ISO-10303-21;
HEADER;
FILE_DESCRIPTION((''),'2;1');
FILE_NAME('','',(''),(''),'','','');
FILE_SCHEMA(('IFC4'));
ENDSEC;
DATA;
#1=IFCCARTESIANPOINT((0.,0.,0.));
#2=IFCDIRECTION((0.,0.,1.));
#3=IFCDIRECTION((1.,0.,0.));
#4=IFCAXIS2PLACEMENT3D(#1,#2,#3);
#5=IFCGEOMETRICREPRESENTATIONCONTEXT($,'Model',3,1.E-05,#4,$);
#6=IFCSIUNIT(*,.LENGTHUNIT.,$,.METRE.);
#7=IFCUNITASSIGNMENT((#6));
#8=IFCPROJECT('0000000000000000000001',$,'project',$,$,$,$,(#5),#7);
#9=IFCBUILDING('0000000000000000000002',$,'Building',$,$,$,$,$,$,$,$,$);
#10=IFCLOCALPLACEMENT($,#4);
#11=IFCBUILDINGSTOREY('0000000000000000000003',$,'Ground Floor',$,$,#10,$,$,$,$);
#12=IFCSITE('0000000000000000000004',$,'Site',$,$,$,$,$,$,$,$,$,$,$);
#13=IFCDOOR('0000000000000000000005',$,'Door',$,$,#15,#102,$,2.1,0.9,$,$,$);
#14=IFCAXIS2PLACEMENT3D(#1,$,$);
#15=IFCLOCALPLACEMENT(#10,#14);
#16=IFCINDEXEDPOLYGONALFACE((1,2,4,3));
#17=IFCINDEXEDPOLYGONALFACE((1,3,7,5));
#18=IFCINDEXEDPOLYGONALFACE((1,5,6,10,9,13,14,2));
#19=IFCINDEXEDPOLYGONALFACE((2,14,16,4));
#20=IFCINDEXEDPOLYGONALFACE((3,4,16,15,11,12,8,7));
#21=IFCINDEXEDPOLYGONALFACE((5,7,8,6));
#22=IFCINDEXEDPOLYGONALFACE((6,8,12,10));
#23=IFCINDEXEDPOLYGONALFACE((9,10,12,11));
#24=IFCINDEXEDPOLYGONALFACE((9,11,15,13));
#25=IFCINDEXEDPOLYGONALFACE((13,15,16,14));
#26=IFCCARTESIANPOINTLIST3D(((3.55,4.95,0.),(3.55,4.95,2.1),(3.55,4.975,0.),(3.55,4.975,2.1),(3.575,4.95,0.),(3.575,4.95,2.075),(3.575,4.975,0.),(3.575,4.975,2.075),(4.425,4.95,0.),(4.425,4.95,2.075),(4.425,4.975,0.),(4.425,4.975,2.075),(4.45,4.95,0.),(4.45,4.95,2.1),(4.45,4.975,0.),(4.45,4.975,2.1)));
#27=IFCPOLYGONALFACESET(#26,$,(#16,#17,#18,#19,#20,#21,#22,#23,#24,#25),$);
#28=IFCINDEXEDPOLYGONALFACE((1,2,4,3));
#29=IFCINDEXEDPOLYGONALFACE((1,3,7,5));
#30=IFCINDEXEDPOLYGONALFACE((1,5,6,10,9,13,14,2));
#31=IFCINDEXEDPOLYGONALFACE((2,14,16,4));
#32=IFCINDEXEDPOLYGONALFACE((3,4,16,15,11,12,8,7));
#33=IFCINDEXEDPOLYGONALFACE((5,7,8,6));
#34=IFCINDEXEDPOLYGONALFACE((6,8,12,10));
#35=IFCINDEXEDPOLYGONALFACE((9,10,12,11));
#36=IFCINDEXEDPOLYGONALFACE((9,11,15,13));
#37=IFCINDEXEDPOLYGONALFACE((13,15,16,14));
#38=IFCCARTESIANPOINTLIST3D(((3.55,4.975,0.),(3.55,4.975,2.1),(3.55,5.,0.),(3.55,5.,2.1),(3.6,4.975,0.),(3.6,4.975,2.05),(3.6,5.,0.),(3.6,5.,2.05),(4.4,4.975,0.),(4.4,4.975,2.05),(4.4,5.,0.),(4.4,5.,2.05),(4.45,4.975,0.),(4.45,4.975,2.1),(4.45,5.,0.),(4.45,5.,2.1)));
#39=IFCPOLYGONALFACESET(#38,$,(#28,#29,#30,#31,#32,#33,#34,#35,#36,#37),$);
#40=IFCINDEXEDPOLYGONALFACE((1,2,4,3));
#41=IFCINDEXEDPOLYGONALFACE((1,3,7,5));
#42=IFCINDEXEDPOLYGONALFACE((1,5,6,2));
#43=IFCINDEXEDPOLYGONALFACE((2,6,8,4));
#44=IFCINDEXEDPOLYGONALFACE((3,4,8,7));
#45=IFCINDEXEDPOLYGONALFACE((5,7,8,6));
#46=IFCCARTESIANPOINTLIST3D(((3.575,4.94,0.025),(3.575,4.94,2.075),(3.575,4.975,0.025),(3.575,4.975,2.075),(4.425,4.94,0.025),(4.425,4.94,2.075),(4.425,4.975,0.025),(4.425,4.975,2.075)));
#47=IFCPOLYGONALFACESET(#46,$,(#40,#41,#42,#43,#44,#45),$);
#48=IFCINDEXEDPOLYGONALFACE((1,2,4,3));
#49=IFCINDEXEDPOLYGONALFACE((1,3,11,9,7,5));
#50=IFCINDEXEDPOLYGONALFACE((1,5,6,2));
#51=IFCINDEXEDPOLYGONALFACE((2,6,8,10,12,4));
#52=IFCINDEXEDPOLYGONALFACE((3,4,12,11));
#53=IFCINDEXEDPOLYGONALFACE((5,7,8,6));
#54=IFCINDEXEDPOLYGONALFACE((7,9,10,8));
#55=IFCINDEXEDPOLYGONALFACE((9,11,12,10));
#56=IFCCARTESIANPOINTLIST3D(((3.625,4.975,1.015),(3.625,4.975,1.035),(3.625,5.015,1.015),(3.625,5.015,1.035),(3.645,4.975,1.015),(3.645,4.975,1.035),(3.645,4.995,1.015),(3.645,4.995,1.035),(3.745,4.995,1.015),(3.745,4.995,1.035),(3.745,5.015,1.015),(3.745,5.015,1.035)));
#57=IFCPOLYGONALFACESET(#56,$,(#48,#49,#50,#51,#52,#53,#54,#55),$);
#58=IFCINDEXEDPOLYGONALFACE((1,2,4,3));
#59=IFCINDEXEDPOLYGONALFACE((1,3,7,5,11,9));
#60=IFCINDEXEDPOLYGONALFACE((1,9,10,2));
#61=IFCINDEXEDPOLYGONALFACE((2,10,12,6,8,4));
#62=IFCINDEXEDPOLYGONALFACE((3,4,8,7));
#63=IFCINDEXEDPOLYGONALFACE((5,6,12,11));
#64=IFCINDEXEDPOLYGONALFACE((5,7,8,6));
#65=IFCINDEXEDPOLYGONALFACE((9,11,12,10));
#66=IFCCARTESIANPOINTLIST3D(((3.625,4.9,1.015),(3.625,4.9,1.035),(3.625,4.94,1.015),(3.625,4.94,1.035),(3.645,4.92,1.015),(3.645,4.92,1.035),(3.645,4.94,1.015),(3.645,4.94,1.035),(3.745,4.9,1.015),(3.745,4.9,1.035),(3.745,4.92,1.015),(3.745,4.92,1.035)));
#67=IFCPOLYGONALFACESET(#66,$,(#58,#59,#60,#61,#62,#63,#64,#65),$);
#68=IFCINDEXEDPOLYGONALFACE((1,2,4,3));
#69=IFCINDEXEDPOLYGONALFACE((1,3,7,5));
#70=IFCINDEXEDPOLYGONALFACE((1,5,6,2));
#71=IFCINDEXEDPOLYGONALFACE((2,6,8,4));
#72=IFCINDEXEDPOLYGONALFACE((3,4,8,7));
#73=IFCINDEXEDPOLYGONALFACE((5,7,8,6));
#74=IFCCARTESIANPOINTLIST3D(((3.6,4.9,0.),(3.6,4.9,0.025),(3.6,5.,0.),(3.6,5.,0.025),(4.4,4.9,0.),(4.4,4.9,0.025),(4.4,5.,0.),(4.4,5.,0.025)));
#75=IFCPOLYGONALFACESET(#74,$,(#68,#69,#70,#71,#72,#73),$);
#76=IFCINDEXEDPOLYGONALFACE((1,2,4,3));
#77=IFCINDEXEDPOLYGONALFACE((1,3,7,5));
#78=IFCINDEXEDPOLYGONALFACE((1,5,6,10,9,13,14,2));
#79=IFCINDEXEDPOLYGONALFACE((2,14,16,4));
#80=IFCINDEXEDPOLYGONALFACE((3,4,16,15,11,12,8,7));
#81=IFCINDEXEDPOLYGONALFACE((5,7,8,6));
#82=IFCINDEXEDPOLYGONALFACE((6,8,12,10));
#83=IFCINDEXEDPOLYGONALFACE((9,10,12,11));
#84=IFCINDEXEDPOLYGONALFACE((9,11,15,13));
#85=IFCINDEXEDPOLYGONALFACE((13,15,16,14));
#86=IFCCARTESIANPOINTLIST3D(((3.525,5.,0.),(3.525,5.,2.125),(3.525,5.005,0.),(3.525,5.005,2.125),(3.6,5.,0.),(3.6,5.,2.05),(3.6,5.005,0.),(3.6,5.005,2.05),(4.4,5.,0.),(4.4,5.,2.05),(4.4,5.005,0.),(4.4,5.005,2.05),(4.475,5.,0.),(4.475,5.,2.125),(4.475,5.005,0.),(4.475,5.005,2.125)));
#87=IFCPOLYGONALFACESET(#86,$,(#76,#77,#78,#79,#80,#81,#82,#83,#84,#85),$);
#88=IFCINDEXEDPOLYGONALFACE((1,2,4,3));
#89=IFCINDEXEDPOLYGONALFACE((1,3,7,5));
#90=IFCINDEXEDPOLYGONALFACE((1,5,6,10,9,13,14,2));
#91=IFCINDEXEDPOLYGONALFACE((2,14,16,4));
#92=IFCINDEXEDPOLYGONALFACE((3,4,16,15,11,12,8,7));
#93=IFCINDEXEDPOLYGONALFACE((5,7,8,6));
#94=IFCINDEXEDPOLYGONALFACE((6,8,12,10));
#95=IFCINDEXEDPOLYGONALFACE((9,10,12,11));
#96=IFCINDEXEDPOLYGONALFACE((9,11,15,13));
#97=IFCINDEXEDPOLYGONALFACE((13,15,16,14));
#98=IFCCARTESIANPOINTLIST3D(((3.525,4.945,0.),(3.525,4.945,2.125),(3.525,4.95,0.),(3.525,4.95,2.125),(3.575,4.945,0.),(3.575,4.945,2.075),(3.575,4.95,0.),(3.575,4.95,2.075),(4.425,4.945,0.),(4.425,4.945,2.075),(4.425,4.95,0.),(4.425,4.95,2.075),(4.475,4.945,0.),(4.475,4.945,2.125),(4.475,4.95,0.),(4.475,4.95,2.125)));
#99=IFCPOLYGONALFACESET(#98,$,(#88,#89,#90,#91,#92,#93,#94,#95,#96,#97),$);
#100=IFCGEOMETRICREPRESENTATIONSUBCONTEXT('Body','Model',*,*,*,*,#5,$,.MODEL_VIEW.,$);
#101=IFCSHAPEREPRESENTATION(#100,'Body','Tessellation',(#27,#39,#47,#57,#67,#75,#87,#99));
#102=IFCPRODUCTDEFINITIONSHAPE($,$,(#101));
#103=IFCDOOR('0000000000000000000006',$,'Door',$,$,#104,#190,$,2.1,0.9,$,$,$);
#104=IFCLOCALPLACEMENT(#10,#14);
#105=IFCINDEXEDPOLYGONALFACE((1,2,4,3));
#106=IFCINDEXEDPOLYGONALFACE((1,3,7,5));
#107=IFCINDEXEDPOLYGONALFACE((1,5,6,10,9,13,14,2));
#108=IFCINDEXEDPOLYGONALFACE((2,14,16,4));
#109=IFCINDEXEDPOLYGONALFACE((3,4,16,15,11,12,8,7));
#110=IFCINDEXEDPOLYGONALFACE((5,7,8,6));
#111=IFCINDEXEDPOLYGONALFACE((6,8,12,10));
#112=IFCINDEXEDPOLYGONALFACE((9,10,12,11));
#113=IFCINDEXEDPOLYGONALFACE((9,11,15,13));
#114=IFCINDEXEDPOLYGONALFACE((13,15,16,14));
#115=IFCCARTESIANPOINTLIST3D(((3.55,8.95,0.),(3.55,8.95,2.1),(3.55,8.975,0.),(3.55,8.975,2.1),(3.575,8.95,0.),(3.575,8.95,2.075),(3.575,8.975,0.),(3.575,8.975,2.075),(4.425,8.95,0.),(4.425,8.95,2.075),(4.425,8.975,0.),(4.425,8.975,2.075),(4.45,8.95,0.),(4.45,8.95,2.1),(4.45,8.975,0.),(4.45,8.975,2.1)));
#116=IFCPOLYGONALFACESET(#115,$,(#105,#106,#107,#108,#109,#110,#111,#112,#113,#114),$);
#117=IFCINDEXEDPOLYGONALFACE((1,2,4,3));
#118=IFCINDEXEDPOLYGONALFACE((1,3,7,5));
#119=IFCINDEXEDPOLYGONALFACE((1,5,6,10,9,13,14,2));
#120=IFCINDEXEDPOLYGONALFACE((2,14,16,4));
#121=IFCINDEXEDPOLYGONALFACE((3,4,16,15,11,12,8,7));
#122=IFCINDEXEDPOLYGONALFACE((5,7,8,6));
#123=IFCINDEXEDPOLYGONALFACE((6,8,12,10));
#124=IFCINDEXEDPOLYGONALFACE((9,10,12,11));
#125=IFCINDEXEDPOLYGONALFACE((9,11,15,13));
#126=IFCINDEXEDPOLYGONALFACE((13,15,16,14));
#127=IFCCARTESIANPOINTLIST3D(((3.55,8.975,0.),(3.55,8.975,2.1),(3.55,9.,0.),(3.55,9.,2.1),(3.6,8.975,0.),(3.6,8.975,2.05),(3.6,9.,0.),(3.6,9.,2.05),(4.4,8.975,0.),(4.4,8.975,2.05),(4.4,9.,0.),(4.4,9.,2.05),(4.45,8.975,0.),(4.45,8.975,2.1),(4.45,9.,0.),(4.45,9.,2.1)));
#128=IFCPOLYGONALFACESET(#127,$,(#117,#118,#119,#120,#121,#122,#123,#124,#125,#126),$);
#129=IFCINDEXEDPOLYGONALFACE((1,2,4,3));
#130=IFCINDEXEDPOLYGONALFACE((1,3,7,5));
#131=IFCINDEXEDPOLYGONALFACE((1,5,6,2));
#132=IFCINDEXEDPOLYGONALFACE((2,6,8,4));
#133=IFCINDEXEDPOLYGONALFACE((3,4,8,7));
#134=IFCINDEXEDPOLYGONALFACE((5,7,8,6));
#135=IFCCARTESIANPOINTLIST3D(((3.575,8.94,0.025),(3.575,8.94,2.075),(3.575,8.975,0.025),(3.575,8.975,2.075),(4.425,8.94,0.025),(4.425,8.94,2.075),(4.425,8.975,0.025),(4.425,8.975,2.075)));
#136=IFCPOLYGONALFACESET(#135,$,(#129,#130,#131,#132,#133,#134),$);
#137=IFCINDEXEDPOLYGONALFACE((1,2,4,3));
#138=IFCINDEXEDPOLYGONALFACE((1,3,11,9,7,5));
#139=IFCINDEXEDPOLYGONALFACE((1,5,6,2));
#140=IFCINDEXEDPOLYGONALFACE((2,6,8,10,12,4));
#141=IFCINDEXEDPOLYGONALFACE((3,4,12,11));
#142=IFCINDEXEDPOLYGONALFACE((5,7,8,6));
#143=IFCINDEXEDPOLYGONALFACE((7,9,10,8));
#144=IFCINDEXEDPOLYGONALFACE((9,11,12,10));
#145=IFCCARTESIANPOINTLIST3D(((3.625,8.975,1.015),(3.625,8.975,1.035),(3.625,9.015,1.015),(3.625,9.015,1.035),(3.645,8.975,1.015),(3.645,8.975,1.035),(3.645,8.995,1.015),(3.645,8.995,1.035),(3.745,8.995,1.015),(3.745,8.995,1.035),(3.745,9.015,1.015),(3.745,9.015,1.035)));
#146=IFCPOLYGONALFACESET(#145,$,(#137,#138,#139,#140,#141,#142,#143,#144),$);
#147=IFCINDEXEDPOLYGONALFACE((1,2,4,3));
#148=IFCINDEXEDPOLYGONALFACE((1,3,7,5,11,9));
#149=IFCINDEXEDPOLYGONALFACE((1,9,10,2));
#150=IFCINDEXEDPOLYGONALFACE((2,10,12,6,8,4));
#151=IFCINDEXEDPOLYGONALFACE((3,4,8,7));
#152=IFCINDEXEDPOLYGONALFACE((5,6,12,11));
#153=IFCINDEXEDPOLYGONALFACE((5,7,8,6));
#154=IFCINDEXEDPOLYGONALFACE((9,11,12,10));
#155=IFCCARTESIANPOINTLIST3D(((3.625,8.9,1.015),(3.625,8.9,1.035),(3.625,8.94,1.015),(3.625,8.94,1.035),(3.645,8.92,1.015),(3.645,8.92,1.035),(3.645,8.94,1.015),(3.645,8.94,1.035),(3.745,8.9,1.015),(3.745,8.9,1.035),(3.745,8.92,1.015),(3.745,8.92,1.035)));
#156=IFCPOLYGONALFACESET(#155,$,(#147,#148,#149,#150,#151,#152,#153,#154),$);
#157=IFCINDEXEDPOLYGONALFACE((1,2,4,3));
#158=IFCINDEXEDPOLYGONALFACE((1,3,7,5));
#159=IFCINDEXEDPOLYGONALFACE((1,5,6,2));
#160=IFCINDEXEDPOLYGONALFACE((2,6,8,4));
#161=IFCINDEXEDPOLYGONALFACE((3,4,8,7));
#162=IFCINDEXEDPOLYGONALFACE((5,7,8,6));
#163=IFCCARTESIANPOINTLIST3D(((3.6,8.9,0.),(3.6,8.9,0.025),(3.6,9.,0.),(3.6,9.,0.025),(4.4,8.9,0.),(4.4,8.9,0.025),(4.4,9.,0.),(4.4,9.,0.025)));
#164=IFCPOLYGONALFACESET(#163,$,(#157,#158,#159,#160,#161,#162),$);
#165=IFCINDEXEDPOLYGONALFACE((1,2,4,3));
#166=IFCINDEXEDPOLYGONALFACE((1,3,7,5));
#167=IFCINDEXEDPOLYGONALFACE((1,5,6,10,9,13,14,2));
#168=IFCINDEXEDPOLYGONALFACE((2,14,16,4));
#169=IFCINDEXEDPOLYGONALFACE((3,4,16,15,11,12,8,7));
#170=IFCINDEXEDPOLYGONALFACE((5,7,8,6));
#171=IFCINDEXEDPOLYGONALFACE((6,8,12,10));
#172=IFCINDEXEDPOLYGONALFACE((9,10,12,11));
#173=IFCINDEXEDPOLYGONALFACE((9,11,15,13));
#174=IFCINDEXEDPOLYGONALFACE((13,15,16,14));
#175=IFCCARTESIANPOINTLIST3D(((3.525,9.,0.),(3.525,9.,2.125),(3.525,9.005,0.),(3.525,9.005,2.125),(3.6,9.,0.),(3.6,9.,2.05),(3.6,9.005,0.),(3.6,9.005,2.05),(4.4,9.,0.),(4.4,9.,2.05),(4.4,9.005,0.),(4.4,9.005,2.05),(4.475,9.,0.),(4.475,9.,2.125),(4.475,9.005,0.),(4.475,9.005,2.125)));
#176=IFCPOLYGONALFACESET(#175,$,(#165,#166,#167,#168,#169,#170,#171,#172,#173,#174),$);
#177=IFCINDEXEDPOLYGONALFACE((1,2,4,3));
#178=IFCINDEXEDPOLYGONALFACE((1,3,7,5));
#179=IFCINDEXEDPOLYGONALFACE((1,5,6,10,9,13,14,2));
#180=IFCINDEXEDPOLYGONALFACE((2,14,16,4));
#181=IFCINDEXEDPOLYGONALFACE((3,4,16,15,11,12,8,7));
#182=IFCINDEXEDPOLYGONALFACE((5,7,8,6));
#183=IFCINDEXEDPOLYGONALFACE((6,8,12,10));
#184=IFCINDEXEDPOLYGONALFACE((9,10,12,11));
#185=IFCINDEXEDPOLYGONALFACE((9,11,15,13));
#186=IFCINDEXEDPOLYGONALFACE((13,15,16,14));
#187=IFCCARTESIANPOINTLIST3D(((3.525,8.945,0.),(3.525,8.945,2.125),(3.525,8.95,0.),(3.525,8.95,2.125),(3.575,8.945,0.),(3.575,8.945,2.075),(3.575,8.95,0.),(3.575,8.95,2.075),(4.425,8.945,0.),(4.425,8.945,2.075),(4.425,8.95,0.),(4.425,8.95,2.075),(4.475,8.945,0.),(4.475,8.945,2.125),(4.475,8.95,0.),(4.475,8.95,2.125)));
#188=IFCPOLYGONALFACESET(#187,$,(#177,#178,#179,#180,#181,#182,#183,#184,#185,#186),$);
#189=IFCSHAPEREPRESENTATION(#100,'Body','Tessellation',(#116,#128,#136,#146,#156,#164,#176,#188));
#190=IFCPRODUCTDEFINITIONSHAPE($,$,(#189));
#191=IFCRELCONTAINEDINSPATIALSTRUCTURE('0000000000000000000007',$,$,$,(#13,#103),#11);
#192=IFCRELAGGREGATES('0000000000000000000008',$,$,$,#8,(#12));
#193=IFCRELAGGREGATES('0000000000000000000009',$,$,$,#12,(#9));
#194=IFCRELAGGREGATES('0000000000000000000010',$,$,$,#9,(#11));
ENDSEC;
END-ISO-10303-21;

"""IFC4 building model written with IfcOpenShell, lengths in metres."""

from ifc_helpers import new_model, si_unit, frame, origin_with_axes, place, context, subcontext, project, spatial, line, indexed_curve, outline, extrude, element, save


model = new_model("IFC4")

# Units and contexts
model_context = context("Model", 3, precision=1e-05, world=origin_with_axes())
body_context = subcontext(model_context, "Body", "Model", "MODEL_VIEW")
ifc_project = project(units=[si_unit("LENGTHUNIT", "METRE")], contexts=[model_context])

# Site, building, storey
site = spatial("IfcSite", under=ifc_project, Name="Site")
building = spatial("IfcBuilding", under=site, Name="Building")
storey_placement = place(None, origin_with_axes())
storey = spatial("IfcBuildingStorey", under=building, at=storey_placement, Name="Ground Floor")

# Doors
door_1_placement = place(storey_placement, frame((4.45, 5.0, 0.0), z_axis=(0.0, 0.0, 1.0), x_axis=(-1.0, 0.0, 0.0)))
element("IfcDoor", 1, at=door_1_placement, inside=storey, Name="Door", OverallHeight=2.1, OverallWidth=0.9, context=body_context, shape_type="SweptSolid", body=[
    extrude(outline(indexed_curve([(0.0, 0.0), (0.0, 2.1), (0.9, 2.1), (0.9, 0.0), (0.875, 0.0), (0.875, 2.075), (0.025, 2.075), (0.025, 0.0)], segments=[line(1, 2, 3, 4, 5, 6, 7, 8, 1)])), frame((0.0, 0.025, 0.0), z_axis=(0.0, -1.0, 0.0), x_axis=(1.0, 0.0, 0.0)), (0.0, 0.0, -1.0), 0.025),
    extrude(outline(indexed_curve([(0.0, 0.0), (0.0, 2.1), (0.9, 2.1), (0.9, 0.0), (0.85, 0.0), (0.85, 2.05), (0.05, 2.05), (0.05, 0.0)], segments=[line(1, 2, 3, 4, 5, 6, 7, 8, 1)])), frame((0.0, 0.0, 0.0), z_axis=(0.0, -1.0, 0.0), x_axis=(1.0, 0.0, 0.0)), (0.0, 0.0, -1.0), 0.025),
    extrude(outline(indexed_curve([(0.0, 0.0), (0.85, 0.0), (0.85, 0.035), (0.0, 0.035)], segments=[line(1, 2, 3, 4, 1)])), frame((0.025, 0.025, 0.025), z_axis=(0.0, 0.0, 1.0), x_axis=(1.0, 0.0, 0.0)), (0.0, 0.0, 1.0), 2.05),
    extrude(outline(indexed_curve([(0.0, 0.0), (0.0, -0.04), (-0.12, -0.04), (-0.12, -0.02), (-0.02, -0.02), (-0.02, 0.0)], segments=[line(1, 2, 3, 4, 5, 6, 1)])), frame((0.825, 0.025, 1.015), z_axis=(0.0, 0.0, 1.0), x_axis=(1.0, 0.0, 0.0)), (0.0, 0.0, 1.0), 0.02),
    extrude(outline(indexed_curve([(0.0, 0.0), (0.0, 0.04), (-0.12, 0.04), (-0.12, 0.02), (-0.02, 0.02), (-0.02, 0.0)], segments=[line(1, 2, 3, 4, 5, 6, 1)])), frame((0.825, 0.06, 1.015), z_axis=(0.0, 0.0, 1.0), x_axis=(1.0, 0.0, 0.0)), (0.0, 0.0, 1.0), 0.02),
    extrude(outline(indexed_curve([(0.0, 0.0), (0.8, 0.0), (0.8, 0.1), (0.0, 0.1)], segments=[line(1, 2, 3, 4, 1)])), frame((0.05, 0.0, 0.0), z_axis=(0.0, 0.0, 1.0), x_axis=(1.0, 0.0, 0.0)), (0.0, 0.0, 1.0), 0.025),
    extrude(outline(indexed_curve([(0.0, 0.0), (0.0, 2.125), (0.95, 2.125), (0.95, 0.0), (0.875, 0.0), (0.875, 2.05), (0.075, 2.05), (0.075, 0.0)], segments=[line(1, 2, 3, 4, 5, 6, 7, 8, 1)])), frame((-0.025, -0.005, 0.0), z_axis=(0.0, -1.0, 0.0), x_axis=(1.0, 0.0, 0.0)), (0.0, 0.0, -1.0), 0.005),
    extrude(outline(indexed_curve([(0.0, 0.0), (0.0, 2.125), (0.95, 2.125), (0.95, 0.0), (0.9, 0.0), (0.9, 2.075), (0.05, 2.075), (0.05, 0.0)], segments=[line(1, 2, 3, 4, 5, 6, 7, 8, 1)])), frame((-0.025, 0.05, 0.0), z_axis=(0.0, -1.0, 0.0), x_axis=(1.0, 0.0, 0.0)), (0.0, 0.0, -1.0), 0.005),
])
door_2_placement = place(storey_placement, frame((4.45, 9.0, 0.0), z_axis=(0.0, 0.0, 1.0), x_axis=(-1.0, 0.0, 0.0)))
element("IfcDoor", 2, at=door_2_placement, inside=storey, Name="Door", OverallHeight=2.1, OverallWidth=0.9, context=body_context, shape_type="SweptSolid", body=[
    extrude(outline(indexed_curve([(0.0, 0.0), (0.0, 2.1), (0.9, 2.1), (0.9, 0.0), (0.875, 0.0), (0.875, 2.075), (0.025, 2.075), (0.025, 0.0)], segments=[line(1, 2, 3, 4, 5, 6, 7, 8, 1)])), frame((0.0, 0.025, 0.0), z_axis=(0.0, -1.0, 0.0), x_axis=(1.0, 0.0, 0.0)), (0.0, 0.0, -1.0), 0.025),
    extrude(outline(indexed_curve([(0.0, 0.0), (0.0, 2.1), (0.9, 2.1), (0.9, 0.0), (0.85, 0.0), (0.85, 2.05), (0.05, 2.05), (0.05, 0.0)], segments=[line(1, 2, 3, 4, 5, 6, 7, 8, 1)])), frame((0.0, 0.0, 0.0), z_axis=(0.0, -1.0, 0.0), x_axis=(1.0, 0.0, 0.0)), (0.0, 0.0, -1.0), 0.025),
    extrude(outline(indexed_curve([(0.0, 0.0), (0.85, 0.0), (0.85, 0.035), (0.0, 0.035)], segments=[line(1, 2, 3, 4, 1)])), frame((0.025, 0.025, 0.025), z_axis=(0.0, 0.0, 1.0), x_axis=(1.0, 0.0, 0.0)), (0.0, 0.0, 1.0), 2.05),
    extrude(outline(indexed_curve([(0.0, 0.0), (0.0, -0.04), (-0.12, -0.04), (-0.12, -0.02), (-0.02, -0.02), (-0.02, 0.0)], segments=[line(1, 2, 3, 4, 5, 6, 1)])), frame((0.825, 0.025, 1.015), z_axis=(0.0, 0.0, 1.0), x_axis=(1.0, 0.0, 0.0)), (0.0, 0.0, 1.0), 0.02),
    extrude(outline(indexed_curve([(0.0, 0.0), (0.0, 0.04), (-0.12, 0.04), (-0.12, 0.02), (-0.02, 0.02), (-0.02, 0.0)], segments=[line(1, 2, 3, 4, 5, 6, 1)])), frame((0.825, 0.06, 1.015), z_axis=(0.0, 0.0, 1.0), x_axis=(1.0, 0.0, 0.0)), (0.0, 0.0, 1.0), 0.02),
    extrude(outline(indexed_curve([(0.0, 0.0), (0.8, 0.0), (0.8, 0.1), (0.0, 0.1)], segments=[line(1, 2, 3, 4, 1)])), frame((0.05, 0.0, 0.0), z_axis=(0.0, 0.0, 1.0), x_axis=(1.0, 0.0, 0.0)), (0.0, 0.0, 1.0), 0.025),
    extrude(outline(indexed_curve([(0.0, 0.0), (0.0, 2.125), (0.95, 2.125), (0.95, 0.0), (0.875, 0.0), (0.875, 2.05), (0.075, 2.05), (0.075, 0.0)], segments=[line(1, 2, 3, 4, 5, 6, 7, 8, 1)])), frame((-0.025, -0.005, 0.0), z_axis=(0.0, -1.0, 0.0), x_axis=(1.0, 0.0, 0.0)), (0.0, 0.0, -1.0), 0.005),
    extrude(outline(indexed_curve([(0.0, 0.0), (0.0, 2.125), (0.95, 2.125), (0.95, 0.0), (0.9, 0.0), (0.9, 2.075), (0.05, 2.075), (0.05, 0.0)], segments=[line(1, 2, 3, 4, 5, 6, 7, 8, 1)])), frame((-0.025, 0.05, 0.0), z_axis=(0.0, -1.0, 0.0), x_axis=(1.0, 0.0, 0.0)), (0.0, 0.0, -1.0), 0.005),
])

save(model, "model.ifc")
